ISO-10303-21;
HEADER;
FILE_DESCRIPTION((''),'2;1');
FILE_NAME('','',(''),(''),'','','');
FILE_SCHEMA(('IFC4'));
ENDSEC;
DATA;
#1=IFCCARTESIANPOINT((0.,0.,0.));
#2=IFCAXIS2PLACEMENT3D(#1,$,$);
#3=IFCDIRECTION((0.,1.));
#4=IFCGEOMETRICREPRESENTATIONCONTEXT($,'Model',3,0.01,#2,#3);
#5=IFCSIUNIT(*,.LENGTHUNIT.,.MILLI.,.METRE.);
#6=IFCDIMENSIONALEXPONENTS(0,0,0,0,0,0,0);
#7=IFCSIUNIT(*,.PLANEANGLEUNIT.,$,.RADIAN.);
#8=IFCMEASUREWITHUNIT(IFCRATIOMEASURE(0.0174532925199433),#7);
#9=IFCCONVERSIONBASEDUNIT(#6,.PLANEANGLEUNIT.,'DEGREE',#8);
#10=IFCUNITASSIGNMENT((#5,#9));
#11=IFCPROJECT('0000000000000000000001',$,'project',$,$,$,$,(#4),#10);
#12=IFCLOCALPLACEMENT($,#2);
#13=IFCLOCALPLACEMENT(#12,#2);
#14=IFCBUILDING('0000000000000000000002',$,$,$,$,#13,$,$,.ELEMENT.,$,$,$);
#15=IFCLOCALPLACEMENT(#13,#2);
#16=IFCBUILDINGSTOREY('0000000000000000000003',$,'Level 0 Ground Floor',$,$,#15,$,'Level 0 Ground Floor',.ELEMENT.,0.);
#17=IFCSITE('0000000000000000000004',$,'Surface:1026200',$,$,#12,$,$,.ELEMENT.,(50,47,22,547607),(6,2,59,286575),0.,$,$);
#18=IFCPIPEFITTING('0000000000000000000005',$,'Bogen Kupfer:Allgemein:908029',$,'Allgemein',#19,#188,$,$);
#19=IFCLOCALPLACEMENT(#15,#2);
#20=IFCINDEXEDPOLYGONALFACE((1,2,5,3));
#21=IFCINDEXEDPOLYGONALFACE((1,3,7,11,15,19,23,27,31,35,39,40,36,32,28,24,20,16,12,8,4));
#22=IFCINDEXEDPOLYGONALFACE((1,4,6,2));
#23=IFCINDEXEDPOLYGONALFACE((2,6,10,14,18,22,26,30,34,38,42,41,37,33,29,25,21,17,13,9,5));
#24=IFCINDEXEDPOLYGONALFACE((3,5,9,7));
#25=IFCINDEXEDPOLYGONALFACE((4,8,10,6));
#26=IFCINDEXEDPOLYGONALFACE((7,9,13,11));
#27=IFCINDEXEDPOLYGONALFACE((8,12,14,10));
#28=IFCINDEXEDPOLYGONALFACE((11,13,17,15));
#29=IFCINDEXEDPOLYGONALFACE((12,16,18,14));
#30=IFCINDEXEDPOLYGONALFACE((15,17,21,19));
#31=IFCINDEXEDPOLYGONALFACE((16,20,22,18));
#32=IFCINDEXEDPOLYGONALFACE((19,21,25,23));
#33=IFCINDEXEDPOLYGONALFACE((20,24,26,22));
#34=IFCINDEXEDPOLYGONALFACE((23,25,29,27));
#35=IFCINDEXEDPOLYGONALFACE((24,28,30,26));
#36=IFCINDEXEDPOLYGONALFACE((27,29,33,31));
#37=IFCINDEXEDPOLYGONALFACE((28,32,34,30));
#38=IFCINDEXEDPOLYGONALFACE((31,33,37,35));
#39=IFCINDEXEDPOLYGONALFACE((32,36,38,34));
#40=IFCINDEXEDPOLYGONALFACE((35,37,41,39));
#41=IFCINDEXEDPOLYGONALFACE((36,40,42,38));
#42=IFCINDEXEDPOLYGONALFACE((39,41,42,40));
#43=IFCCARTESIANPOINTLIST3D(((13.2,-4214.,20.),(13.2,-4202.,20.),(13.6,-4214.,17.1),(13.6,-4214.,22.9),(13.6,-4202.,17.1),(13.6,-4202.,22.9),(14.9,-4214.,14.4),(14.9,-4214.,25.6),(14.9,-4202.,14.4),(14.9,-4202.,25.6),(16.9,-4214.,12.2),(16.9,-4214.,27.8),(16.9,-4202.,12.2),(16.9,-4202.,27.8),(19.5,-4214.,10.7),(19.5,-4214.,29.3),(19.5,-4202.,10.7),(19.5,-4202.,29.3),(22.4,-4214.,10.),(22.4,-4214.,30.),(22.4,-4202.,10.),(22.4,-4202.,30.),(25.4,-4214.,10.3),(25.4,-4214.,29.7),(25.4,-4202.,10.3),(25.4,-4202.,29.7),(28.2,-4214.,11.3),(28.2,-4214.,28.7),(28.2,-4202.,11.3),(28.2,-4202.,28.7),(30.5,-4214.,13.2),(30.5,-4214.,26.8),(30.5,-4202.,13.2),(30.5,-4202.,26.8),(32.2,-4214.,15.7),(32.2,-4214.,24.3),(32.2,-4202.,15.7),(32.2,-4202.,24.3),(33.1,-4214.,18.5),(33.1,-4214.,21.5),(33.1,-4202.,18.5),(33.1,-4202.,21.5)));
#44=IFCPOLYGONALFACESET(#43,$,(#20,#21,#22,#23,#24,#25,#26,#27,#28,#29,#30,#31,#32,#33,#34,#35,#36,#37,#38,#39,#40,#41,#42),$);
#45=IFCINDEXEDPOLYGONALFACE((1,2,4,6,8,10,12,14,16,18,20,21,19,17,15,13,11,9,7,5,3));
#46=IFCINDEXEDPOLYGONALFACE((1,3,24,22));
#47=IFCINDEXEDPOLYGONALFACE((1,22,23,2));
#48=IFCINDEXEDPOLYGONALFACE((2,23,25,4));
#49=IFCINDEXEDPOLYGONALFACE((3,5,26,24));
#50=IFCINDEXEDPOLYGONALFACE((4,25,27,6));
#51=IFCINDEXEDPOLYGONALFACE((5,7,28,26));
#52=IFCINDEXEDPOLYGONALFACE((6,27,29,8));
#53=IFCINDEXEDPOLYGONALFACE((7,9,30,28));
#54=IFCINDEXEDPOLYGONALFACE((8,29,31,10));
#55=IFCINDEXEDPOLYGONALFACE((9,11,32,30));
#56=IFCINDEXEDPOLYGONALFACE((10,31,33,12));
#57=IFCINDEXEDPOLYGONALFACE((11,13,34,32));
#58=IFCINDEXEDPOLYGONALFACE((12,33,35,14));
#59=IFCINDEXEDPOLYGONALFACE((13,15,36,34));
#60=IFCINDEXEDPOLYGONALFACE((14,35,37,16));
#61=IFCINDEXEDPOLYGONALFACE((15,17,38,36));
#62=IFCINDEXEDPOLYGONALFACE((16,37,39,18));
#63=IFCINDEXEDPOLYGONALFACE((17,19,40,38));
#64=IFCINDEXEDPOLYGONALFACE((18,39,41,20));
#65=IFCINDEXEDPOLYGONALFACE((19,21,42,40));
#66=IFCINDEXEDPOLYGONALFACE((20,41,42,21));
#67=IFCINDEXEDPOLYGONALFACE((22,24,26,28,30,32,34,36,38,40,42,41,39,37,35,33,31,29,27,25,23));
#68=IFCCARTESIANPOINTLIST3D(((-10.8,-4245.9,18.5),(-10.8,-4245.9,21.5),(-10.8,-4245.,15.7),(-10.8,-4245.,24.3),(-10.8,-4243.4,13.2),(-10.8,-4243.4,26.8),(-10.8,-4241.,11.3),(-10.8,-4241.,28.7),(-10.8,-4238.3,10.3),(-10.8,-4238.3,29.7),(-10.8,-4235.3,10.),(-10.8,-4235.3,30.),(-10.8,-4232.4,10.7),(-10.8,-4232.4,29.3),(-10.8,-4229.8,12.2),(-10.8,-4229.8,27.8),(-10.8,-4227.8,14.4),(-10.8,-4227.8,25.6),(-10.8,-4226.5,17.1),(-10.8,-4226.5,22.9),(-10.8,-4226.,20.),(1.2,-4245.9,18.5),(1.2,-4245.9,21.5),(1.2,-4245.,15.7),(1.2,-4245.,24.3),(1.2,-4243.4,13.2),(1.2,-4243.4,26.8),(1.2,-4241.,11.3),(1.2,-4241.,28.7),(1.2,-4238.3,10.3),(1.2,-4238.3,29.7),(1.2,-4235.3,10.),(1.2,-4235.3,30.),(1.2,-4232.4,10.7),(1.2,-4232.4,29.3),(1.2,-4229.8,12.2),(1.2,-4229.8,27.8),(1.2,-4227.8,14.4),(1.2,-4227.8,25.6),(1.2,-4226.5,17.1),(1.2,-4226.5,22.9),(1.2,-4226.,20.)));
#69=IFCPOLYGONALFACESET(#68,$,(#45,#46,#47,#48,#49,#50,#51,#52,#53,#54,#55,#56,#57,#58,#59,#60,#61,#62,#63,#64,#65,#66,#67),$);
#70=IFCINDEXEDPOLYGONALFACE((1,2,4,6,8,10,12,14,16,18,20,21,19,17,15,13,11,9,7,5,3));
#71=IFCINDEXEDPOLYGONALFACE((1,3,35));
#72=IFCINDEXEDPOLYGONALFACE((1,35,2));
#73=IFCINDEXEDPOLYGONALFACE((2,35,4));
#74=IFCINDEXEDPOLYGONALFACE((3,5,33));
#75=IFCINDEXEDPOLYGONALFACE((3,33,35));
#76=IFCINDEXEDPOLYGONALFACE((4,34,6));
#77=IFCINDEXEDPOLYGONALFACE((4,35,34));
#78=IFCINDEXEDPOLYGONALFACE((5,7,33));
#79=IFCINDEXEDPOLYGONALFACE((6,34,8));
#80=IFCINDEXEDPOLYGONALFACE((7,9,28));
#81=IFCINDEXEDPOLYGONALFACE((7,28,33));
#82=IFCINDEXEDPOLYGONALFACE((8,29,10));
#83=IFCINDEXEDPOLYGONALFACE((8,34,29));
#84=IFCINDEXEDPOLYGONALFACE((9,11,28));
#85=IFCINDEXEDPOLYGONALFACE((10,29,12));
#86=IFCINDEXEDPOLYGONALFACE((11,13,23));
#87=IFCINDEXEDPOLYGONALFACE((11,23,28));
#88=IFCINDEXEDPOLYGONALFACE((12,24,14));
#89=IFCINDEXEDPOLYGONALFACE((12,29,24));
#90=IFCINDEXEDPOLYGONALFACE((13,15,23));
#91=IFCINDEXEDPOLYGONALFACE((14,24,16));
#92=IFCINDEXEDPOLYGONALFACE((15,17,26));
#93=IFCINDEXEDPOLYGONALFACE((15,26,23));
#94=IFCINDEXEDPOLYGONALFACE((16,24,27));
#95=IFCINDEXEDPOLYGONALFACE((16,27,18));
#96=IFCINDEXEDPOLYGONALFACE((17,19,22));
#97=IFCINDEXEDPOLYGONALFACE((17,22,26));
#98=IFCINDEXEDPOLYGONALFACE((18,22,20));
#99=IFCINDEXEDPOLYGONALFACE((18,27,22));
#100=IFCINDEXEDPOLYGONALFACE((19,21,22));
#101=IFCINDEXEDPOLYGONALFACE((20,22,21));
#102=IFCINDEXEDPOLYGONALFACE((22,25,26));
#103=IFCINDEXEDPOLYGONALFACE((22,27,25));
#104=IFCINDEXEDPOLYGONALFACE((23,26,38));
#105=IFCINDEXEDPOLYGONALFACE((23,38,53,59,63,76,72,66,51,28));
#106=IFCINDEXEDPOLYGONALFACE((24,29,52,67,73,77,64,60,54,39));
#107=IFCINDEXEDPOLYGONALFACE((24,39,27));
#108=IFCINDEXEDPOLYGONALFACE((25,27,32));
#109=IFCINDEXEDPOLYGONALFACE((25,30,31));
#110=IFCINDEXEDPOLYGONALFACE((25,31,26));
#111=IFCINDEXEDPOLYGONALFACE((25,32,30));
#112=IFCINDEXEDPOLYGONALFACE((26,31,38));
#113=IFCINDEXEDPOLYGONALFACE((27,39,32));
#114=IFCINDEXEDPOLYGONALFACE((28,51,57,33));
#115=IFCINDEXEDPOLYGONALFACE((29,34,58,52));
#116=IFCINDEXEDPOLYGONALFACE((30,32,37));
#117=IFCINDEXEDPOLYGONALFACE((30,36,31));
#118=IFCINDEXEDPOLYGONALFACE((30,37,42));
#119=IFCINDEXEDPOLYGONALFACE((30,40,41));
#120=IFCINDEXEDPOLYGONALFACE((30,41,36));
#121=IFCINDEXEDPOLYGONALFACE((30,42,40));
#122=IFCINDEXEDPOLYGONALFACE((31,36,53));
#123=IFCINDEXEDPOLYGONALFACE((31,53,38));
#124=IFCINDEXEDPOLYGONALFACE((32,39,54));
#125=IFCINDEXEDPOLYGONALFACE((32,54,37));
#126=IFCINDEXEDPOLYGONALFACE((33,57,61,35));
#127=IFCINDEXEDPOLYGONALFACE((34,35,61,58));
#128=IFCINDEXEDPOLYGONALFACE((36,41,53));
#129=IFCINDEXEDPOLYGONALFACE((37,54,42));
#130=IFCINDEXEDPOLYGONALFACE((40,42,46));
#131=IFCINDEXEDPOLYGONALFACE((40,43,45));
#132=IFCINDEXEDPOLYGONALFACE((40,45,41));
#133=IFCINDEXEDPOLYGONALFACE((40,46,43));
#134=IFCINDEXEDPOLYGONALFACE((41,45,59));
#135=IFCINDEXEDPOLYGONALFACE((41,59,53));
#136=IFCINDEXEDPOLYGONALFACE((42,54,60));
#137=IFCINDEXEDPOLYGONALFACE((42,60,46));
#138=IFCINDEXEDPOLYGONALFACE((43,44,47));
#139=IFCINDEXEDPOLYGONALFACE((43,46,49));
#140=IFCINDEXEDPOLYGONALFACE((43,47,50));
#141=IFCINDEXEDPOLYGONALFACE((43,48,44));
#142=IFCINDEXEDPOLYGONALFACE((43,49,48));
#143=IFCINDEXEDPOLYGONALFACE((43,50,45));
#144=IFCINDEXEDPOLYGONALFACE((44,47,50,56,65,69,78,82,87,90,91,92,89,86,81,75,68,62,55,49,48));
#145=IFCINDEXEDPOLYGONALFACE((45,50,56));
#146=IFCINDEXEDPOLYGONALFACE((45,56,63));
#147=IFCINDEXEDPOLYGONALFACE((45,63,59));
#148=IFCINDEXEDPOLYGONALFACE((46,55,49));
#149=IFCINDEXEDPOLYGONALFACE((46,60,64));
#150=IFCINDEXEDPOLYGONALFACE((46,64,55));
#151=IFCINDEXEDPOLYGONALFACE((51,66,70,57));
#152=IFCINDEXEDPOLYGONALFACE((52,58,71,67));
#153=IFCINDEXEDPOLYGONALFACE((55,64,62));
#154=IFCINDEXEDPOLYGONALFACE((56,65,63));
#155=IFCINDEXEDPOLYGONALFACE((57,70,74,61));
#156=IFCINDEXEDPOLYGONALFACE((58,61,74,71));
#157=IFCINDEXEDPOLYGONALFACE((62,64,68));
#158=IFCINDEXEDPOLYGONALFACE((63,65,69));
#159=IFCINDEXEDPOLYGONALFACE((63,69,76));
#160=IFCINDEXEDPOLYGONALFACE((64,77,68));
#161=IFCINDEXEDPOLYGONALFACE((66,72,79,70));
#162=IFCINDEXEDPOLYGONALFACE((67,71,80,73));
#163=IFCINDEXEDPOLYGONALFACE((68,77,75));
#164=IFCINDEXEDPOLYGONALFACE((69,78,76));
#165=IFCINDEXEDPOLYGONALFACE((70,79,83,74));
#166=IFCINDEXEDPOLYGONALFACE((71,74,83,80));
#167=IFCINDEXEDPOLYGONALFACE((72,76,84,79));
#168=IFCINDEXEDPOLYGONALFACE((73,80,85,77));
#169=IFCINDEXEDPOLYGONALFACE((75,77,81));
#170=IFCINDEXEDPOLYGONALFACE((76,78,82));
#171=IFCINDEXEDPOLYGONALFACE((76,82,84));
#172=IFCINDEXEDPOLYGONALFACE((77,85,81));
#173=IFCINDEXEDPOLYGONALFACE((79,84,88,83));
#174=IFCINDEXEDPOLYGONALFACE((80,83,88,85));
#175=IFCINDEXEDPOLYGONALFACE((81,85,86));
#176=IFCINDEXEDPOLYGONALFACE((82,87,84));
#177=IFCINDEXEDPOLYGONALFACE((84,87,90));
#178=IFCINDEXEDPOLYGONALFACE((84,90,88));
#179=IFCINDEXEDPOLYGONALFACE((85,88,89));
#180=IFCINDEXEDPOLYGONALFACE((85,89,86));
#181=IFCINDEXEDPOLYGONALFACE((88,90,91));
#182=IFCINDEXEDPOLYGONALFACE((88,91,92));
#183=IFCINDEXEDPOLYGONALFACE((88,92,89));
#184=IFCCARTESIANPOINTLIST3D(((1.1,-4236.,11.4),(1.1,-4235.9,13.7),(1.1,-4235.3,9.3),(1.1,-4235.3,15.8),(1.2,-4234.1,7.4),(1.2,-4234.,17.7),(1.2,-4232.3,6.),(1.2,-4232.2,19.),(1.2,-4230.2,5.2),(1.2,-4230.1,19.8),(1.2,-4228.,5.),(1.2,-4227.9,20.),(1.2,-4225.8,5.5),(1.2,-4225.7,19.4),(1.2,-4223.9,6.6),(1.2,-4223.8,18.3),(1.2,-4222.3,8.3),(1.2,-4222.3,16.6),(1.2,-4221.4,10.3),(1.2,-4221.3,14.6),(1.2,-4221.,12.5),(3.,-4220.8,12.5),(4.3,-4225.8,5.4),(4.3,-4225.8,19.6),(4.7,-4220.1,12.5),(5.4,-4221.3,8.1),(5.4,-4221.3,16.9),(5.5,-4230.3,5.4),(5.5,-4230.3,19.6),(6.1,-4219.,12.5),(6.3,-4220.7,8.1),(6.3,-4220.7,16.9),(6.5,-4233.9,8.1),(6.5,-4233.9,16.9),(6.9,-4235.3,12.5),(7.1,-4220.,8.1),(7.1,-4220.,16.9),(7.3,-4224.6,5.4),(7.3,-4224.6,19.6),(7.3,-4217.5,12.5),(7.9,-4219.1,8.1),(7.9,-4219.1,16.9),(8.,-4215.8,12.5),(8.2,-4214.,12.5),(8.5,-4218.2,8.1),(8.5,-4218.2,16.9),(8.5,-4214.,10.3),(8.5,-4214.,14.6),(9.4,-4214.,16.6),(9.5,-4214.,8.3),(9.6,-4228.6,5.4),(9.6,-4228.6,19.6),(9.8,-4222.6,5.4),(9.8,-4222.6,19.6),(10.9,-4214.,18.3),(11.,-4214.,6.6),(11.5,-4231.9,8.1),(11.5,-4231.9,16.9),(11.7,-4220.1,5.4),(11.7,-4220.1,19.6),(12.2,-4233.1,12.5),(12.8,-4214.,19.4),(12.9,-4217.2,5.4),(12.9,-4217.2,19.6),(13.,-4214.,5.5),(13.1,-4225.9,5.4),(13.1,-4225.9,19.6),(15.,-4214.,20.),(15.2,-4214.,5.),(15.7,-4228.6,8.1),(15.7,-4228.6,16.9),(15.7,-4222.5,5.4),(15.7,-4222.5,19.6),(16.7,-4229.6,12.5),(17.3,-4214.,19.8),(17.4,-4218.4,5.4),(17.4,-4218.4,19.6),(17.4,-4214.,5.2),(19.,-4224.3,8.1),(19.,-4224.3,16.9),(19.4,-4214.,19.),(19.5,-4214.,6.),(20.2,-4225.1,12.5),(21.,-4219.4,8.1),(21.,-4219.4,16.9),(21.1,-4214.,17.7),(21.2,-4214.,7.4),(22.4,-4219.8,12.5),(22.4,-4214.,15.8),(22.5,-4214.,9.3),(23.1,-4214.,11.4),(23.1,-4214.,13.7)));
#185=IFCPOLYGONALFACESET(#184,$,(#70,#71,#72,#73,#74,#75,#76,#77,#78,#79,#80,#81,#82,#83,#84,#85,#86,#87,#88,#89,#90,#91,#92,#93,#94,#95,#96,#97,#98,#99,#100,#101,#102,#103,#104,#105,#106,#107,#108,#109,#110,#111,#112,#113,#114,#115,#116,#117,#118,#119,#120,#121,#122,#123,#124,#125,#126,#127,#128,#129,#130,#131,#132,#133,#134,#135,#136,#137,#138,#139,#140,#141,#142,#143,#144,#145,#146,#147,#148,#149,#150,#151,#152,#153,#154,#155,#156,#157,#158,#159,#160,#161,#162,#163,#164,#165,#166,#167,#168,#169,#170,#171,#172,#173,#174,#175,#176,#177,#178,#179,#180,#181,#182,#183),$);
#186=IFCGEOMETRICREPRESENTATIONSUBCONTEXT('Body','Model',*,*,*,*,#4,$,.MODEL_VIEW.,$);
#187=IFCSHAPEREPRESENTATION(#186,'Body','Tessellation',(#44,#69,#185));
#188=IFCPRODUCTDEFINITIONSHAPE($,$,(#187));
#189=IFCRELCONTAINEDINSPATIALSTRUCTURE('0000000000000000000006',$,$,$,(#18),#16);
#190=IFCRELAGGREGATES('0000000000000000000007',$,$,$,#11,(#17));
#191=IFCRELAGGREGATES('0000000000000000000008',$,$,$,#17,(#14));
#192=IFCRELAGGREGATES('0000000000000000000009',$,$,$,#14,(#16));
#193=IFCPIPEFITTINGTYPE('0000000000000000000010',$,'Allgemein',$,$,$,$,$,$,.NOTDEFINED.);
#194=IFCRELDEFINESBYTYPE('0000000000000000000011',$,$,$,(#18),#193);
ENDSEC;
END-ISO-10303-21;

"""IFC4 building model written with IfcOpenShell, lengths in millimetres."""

from ifc_helpers import new_model, entity, si_unit, converted_unit, direction, frame, frame_2d, origin, place, context, subcontext, project, spatial, circle, extrude, source, transform, mapped, type_object, type_shapes, element, save


model = new_model("IFC4")

# Units and contexts
model_context = context("Model", 3, precision=0.01, world=origin(), true_north=direction((0.0, 1.0)))
body_context = subcontext(model_context, "Body", "Model", "MODEL_VIEW")
ifc_project = project(units=[si_unit("LENGTHUNIT", "METRE", prefix="MILLI"), converted_unit("PLANEANGLEUNIT", "DEGREE", entity("IfcRatioMeasure", 0.0174532925199433), si_unit("PLANEANGLEUNIT", "RADIAN"), dimensions=[0, 0, 0, 0, 0, 0, 0])], contexts=[model_context])

# Site, building, storey
site_placement = place(None, origin())
site = spatial("IfcSite", under=ifc_project, at=site_placement, Name="Surface:1026200", CompositionType="ELEMENT", RefLatitude=(50, 47, 22, 547607), RefLongitude=(6, 2, 59, 286575), RefElevation=0.0)
building_placement = place(site_placement, origin())
building = spatial("IfcBuilding", under=site, at=building_placement, CompositionType="ELEMENT")
storey_placement = place(building_placement, origin())
storey = spatial("IfcBuildingStorey", under=building, at=storey_placement, Name="Level 0 Ground Floor", LongName="Level 0 Ground Floor", CompositionType="ELEMENT", Elevation=0.0)

# Pipe fitting
pipe_fitting_type = type_object("IfcPipeFittingType", Name="Allgemein", PredefinedType="NOTDEFINED")
ifc_direction = entity("IfcDirection", [0.0, 0.0, -1.0])
trimmed_curve = entity("IfcTrimmedCurve", entity("IfcCircle", entity("IfcAxis2Placement2D", entity("IfcCartesianPoint", [-14.5, 0.0]), entity("IfcDirection", [0.0, 1.0])), 14.5), [entity("IfcParameterValue", 270.0)], [entity("IfcParameterValue", 0.0)], True, "PARAMETER")
shared_shape_1 = source(origin(), body_context, "Body", "SolidModel", [
    extrude(circle(Radius=10.0, at=frame_2d((0.0, 0.0), x_axis=(1.0, 0.0))), frame((0.0, 22.0, 0.0), z_axis=(0.0, 1.0, 0.0), x_axis=(-1.0, 0.0, 0.0)), (0.0, 0.0, 1.0), 12.0),
    extrude(circle(Radius=10.0, at=frame_2d((0.0, 0.0), x_axis=(1.0, 0.0))), frame((-34.0, 0.0, 0.0), z_axis=(1.0, 0.0, 0.0), x_axis=(0.0, 1.0, 0.0)), (0.0, 0.0, 1.0), 12.0),
    entity("IfcSurfaceCurveSweptAreaSolid", entity("IfcCircleProfileDef", "AREA", None, entity("IfcAxis2Placement2D", entity("IfcCartesianPoint", [0.0, 7.5]), entity("IfcDirection", [1.0, 0.0])), 7.5), entity("IfcAxis2Placement3D", entity("IfcCartesianPoint", [-7.5, 22.0, 0.0]), ifc_direction, entity("IfcDirection", [1.0, 0.0, 0.0])), trimmed_curve, 0.0, 90.0, entity("IfcSurfaceOfLinearExtrusion", entity("IfcArbitraryOpenProfileDef", "CURVE", None, trimmed_curve), entity("IfcAxis2Placement3D", entity("IfcCartesianPoint", [0.0, 0.0, -304.8])), ifc_direction, 1.0)),
])
type_shapes(pipe_fitting_type, [shared_shape_1])
pipe_fitting_1_placement = place(storey_placement, frame((23.2, -4236.0, 20.0)))
element("IfcPipeFitting", 1, at=pipe_fitting_1_placement, inside=storey, type_object=pipe_fitting_type, Name="Bogen Kupfer:Allgemein:908029", ObjectType="Allgemein", context=body_context, shape_type="MappedRepresentation", body=[
    mapped(shared_shape_1, transform((0.0, 0.0, 0.0), scale=1.0)),
])

save(model, "model.ifc")
